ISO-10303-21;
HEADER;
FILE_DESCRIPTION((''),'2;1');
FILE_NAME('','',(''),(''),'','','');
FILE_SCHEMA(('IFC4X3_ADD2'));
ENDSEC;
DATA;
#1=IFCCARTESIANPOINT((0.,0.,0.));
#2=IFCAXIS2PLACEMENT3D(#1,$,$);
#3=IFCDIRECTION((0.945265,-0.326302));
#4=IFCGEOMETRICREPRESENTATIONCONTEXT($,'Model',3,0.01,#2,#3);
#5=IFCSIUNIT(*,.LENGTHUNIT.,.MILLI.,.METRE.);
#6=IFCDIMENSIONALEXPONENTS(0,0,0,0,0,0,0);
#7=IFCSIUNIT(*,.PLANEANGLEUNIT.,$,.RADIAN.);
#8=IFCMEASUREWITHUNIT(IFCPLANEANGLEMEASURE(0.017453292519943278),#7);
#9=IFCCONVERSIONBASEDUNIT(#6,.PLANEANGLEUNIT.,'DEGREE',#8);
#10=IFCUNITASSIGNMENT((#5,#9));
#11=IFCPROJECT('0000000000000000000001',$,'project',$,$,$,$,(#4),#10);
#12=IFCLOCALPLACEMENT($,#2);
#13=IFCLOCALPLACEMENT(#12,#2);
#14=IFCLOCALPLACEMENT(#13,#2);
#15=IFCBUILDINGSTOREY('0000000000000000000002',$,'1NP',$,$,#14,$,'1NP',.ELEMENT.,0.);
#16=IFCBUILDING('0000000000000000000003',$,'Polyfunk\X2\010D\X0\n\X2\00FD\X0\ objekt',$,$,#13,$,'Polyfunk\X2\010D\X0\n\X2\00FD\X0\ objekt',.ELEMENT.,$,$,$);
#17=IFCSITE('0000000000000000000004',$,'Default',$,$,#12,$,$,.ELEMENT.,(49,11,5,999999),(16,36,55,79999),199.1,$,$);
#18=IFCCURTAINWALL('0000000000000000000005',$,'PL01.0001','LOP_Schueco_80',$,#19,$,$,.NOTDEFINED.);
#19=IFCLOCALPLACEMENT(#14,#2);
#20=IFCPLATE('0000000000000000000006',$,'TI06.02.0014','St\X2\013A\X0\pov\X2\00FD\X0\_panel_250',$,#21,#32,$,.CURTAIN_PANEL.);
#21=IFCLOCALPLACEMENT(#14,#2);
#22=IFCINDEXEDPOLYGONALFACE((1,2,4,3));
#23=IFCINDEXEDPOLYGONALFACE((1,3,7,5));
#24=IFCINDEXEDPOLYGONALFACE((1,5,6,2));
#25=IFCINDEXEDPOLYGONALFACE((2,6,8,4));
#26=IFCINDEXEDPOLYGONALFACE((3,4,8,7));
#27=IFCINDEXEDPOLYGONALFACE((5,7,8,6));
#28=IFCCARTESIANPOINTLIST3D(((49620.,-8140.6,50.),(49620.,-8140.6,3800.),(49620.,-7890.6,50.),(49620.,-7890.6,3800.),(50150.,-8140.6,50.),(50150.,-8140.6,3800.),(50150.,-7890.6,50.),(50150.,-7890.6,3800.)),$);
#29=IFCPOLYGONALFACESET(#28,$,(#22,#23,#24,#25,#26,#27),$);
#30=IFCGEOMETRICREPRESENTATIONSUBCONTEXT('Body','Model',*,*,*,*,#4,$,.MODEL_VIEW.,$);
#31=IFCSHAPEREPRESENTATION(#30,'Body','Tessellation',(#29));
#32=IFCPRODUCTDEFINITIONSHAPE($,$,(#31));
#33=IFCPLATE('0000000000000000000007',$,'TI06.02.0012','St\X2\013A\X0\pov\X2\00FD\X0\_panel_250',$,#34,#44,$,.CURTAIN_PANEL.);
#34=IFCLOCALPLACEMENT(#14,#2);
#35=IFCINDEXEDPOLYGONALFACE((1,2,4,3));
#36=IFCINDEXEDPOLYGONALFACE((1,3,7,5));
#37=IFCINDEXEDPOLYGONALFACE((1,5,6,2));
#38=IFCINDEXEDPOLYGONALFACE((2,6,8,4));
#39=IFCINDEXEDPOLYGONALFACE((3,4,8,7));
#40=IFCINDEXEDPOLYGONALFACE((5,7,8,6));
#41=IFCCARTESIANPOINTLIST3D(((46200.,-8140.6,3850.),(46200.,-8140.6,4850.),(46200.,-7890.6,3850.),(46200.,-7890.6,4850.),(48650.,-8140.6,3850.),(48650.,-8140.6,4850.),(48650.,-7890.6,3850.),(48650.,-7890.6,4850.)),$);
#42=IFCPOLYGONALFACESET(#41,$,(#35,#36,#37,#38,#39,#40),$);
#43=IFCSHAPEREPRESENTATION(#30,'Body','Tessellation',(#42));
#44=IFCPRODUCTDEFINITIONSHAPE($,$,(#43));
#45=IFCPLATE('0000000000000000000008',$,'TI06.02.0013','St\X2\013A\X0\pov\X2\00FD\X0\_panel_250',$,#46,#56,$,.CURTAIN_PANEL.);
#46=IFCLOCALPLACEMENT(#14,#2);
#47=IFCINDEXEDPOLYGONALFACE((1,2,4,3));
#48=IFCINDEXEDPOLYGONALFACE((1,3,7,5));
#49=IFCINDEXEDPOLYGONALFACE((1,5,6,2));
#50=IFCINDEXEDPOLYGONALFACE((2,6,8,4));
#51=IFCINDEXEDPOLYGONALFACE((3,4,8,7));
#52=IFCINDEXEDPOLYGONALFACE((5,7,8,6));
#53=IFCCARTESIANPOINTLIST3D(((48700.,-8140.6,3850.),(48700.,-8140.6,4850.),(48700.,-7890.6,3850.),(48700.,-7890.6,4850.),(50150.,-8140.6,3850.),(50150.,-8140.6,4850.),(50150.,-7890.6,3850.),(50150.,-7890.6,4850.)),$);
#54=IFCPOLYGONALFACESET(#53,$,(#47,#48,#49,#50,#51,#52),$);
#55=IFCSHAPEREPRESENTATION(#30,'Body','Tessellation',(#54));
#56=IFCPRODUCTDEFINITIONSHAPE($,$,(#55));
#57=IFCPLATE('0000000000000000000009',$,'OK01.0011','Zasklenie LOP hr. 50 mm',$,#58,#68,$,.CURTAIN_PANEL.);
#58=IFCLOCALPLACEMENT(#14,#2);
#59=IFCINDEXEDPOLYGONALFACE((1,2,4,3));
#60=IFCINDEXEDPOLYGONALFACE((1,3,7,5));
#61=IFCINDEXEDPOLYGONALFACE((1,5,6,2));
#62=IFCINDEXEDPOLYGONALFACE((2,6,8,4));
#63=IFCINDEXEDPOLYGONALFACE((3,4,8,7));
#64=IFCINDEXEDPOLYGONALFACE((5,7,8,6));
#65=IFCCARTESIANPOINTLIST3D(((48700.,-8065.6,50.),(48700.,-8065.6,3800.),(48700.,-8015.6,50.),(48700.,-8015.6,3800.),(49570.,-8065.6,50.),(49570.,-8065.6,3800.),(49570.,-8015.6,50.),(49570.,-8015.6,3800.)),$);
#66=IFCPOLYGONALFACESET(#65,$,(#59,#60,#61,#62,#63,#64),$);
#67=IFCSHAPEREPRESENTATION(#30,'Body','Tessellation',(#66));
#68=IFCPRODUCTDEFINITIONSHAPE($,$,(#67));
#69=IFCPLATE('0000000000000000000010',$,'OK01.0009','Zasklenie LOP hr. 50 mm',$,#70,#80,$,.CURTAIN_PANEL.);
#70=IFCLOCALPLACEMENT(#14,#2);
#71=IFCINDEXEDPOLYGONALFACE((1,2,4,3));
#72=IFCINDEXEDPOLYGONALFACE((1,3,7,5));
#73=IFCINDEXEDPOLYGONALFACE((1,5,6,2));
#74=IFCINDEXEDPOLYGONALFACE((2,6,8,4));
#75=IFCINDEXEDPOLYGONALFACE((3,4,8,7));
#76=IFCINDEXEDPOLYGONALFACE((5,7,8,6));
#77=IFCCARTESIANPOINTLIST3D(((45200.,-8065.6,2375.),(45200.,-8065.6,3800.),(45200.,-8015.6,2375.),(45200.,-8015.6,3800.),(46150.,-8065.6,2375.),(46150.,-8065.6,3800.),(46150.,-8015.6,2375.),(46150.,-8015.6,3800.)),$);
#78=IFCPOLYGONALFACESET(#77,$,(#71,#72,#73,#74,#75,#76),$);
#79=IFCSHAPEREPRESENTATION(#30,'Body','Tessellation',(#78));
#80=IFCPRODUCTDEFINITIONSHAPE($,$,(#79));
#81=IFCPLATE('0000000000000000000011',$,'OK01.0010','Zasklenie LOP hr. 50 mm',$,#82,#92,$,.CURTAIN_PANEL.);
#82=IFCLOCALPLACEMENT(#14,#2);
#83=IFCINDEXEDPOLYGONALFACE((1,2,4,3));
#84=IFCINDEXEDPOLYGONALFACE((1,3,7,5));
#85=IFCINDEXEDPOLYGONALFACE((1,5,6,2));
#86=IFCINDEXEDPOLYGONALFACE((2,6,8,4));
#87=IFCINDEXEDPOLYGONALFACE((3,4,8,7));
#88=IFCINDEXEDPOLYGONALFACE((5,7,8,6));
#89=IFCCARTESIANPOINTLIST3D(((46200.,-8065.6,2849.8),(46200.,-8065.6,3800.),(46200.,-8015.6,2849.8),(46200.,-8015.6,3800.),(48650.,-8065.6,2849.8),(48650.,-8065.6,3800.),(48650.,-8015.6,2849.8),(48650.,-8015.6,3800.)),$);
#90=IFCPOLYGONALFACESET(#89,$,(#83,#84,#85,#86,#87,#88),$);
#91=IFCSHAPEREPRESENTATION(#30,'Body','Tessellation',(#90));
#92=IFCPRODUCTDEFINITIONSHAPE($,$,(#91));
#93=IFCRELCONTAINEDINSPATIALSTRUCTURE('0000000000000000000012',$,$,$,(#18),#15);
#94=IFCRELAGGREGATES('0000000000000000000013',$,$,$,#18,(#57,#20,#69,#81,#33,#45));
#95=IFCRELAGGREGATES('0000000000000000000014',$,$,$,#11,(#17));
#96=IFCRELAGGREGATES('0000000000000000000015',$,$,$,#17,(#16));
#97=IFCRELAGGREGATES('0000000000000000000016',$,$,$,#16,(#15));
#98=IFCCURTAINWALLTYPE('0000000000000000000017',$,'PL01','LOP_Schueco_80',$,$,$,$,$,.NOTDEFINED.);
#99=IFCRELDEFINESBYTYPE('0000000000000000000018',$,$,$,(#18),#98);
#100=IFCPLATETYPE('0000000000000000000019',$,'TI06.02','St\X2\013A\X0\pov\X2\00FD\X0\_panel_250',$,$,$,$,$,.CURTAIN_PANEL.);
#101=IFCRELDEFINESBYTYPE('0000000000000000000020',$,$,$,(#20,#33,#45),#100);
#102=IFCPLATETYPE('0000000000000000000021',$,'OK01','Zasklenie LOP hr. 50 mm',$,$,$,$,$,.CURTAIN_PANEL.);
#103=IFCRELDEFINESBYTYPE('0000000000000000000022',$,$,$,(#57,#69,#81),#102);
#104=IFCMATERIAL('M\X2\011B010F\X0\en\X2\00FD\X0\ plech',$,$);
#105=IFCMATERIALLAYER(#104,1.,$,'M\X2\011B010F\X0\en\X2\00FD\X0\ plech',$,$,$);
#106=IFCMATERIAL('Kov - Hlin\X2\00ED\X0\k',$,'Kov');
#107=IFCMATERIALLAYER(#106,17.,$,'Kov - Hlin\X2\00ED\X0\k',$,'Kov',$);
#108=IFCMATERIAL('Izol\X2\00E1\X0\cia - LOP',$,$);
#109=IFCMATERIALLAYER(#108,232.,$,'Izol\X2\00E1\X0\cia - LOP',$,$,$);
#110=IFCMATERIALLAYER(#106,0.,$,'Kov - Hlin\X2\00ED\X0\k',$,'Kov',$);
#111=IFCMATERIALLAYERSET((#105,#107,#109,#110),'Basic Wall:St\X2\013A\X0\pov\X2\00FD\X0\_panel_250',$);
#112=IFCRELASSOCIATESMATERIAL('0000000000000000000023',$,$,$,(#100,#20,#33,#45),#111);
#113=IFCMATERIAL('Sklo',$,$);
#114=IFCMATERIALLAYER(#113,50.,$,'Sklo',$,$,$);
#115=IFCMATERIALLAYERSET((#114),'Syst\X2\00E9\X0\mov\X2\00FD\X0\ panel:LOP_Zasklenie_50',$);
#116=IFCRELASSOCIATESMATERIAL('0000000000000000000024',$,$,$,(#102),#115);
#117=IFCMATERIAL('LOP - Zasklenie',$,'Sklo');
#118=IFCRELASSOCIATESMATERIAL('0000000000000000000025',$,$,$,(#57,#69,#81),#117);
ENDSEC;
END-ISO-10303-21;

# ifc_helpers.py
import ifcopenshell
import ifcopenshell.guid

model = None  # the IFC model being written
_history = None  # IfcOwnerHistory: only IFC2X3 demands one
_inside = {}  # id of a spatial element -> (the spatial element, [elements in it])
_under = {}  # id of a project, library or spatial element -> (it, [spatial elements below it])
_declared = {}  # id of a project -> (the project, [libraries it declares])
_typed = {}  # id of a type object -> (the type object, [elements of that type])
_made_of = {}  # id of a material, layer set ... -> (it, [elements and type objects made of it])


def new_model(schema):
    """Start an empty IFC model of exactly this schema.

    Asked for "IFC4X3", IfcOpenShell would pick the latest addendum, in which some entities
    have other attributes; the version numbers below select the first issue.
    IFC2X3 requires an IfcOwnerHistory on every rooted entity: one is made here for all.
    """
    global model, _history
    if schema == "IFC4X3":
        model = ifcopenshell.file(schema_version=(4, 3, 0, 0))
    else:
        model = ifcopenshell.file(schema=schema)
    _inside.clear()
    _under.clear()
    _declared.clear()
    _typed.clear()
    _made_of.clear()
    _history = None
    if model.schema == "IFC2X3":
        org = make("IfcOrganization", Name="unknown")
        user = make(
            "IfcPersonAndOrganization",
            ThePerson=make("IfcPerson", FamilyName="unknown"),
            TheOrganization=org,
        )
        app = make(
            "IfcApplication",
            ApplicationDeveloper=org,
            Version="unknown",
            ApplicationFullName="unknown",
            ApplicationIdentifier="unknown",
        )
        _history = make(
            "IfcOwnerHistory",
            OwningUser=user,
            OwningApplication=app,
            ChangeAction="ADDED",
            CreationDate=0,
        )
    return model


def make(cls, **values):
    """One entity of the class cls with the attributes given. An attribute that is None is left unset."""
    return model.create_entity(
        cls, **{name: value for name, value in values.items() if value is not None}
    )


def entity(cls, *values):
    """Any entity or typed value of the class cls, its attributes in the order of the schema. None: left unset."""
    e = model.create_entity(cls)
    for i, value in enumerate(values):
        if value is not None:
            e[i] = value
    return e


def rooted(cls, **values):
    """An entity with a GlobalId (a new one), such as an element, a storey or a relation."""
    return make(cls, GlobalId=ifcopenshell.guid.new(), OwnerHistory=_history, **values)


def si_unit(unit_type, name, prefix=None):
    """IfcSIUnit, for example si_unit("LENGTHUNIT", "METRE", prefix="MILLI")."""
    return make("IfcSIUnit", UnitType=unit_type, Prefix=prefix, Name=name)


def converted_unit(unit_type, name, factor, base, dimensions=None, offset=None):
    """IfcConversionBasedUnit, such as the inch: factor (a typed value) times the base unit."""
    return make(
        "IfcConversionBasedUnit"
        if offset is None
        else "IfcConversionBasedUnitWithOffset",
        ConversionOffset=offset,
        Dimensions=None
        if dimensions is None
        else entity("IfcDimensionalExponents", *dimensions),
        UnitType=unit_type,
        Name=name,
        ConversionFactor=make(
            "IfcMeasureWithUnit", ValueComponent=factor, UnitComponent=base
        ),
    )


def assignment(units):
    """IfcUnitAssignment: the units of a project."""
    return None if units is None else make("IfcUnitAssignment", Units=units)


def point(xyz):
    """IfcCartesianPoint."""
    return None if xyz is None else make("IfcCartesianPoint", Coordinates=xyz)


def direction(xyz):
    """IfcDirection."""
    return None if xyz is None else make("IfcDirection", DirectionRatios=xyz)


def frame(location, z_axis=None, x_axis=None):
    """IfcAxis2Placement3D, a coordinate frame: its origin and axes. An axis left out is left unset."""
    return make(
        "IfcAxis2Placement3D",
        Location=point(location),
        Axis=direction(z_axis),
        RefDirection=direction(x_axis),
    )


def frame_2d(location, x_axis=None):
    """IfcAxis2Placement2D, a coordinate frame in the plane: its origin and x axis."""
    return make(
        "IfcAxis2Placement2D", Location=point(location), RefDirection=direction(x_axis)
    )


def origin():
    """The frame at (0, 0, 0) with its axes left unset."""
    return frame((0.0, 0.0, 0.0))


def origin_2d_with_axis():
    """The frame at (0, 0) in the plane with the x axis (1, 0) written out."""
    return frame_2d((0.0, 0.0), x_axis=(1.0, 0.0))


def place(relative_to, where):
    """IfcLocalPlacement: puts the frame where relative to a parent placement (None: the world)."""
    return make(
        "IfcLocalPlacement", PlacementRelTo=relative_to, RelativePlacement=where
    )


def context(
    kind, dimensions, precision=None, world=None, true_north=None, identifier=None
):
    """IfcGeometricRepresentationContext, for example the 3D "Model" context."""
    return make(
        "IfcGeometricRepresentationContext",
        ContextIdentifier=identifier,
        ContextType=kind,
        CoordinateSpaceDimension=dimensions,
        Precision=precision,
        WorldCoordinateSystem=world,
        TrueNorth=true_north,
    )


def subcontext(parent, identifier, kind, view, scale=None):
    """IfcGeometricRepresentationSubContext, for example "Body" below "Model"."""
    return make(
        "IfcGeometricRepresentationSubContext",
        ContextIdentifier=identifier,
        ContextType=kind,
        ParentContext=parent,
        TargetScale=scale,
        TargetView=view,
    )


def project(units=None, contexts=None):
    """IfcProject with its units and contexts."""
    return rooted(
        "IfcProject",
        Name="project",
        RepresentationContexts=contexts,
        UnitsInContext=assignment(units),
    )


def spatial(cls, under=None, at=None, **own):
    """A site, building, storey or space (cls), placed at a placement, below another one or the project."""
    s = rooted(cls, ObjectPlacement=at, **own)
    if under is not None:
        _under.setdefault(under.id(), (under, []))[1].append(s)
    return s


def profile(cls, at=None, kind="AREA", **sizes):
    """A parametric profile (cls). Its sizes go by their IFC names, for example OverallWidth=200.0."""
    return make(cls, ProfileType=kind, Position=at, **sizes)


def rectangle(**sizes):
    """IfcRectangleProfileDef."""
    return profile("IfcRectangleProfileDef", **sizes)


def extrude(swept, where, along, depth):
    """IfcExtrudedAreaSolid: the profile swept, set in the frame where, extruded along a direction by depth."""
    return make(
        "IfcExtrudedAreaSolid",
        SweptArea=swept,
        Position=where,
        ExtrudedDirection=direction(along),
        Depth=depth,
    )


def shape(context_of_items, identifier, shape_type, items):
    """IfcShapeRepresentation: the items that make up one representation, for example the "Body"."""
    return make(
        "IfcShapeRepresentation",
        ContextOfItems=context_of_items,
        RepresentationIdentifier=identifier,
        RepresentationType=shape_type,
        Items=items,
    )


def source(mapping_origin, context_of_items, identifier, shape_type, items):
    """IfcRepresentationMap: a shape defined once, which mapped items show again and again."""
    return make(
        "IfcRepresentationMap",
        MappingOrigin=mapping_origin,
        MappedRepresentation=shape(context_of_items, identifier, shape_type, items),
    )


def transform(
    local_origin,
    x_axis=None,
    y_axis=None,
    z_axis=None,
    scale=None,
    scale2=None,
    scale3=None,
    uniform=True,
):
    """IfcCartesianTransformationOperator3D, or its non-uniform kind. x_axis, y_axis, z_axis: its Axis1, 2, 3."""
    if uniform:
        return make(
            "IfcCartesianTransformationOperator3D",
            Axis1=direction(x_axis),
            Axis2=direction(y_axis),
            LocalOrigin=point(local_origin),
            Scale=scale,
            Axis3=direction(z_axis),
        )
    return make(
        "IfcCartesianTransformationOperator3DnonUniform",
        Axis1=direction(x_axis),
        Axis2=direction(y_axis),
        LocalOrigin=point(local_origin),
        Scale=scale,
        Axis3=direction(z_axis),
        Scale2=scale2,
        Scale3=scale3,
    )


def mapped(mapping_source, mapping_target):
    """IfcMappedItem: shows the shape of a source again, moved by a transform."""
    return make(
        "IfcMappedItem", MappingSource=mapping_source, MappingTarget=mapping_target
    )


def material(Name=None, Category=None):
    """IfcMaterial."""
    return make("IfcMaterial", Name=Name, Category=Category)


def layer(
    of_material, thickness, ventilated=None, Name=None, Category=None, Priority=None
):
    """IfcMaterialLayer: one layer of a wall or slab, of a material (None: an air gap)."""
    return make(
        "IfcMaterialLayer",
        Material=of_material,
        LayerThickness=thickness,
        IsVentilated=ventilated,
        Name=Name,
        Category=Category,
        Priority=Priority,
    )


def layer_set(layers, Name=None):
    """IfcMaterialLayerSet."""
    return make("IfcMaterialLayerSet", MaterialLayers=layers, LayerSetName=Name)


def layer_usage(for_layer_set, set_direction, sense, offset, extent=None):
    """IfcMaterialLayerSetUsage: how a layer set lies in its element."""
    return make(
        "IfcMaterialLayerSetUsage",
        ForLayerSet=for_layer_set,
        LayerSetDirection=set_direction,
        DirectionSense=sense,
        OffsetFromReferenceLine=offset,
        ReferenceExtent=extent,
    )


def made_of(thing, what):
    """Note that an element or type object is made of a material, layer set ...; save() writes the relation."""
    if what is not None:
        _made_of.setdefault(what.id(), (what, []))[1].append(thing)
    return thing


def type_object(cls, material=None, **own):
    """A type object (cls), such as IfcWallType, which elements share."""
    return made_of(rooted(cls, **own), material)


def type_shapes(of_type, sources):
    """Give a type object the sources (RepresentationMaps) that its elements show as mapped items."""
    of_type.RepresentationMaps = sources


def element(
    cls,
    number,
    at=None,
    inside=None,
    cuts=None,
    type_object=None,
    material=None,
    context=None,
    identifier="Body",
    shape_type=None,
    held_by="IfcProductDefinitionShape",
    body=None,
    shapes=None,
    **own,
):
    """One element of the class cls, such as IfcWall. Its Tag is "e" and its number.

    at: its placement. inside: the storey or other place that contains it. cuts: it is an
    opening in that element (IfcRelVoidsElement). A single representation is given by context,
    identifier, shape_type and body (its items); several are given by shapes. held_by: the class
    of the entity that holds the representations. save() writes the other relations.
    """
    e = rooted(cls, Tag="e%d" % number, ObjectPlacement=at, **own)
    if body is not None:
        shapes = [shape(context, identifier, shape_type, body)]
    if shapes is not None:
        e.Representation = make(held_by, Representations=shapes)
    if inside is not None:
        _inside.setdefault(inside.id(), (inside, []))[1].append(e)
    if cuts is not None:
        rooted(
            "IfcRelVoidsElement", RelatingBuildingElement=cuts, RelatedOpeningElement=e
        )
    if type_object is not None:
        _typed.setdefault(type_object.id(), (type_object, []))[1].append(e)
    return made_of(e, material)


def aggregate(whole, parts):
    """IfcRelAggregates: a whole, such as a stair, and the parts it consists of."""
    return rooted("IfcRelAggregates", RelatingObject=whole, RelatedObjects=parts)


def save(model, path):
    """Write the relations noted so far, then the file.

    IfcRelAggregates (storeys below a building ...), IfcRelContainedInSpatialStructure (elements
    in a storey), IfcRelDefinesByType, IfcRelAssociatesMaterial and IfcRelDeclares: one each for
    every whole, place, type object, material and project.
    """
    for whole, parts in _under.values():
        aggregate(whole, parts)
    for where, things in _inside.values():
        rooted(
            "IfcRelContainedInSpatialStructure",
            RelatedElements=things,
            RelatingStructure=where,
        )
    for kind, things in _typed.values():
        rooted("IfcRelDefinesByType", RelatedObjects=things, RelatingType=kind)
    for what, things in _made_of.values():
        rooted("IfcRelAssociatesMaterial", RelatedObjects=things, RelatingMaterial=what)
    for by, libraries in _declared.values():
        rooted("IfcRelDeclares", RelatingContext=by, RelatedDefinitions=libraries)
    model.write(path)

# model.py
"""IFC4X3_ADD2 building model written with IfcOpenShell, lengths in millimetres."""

from ifc_helpers import new_model, entity, si_unit, converted_unit, direction, frame, frame_2d, origin, origin_2d_with_axis, place, context, subcontext, project, spatial, rectangle, extrude, source, transform, mapped, material, layer, layer_set, layer_usage, type_object, type_shapes, element, aggregate, save


model = new_model("IFC4X3_ADD2")

# Units and contexts
model_context = context("Model", 3, precision=0.01, world=origin(), true_north=direction((0.945265, -0.326302)))
body_context = subcontext(model_context, "Body", "Model", "MODEL_VIEW")
ifc_project = project(units=[si_unit("LENGTHUNIT", "METRE", prefix="MILLI"), converted_unit("PLANEANGLEUNIT", "DEGREE", entity("IfcPlaneAngleMeasure", 0.017453292519943278), si_unit("PLANEANGLEUNIT", "RADIAN"), dimensions=[0, 0, 0, 0, 0, 0, 0])], contexts=[model_context])

# Site, building, storey
site_placement = place(None, origin())
site = spatial("IfcSite", under=ifc_project, at=site_placement, Name="Default", CompositionType="ELEMENT", RefLatitude=(49, 11, 5, 999999), RefLongitude=(16, 36, 55, 79999), RefElevation=199.1)
building_placement = place(site_placement, origin())
building = spatial("IfcBuilding", under=site, at=building_placement, Name="Polyfunkčný objekt", LongName="Polyfunkčný objekt", CompositionType="ELEMENT")
storey_placement = place(building_placement, origin())
storey = spatial("IfcBuildingStorey", under=building, at=storey_placement, Name="1NP", LongName="1NP", CompositionType="ELEMENT", Elevation=0.0)

# Curtain wall, plates
curtain_wall_type = type_object("IfcCurtainWallType", Name="PL01", Description="LOP_Schueco_80", PredefinedType="NOTDEFINED")
curtain_wall_placement = place(storey_placement, origin())
curtain_wall = element("IfcCurtainWall", 1, at=curtain_wall_placement, inside=storey, type_object=curtain_wall_type, Name="PL01.0001", Description="LOP_Schueco_80", PredefinedType="NOTDEFINED")
ifc_material_1 = material(Name="Měďený plech")
ifc_layer_1 = layer(ifc_material_1, 1.0, Name="Měďený plech")
ifc_material_2 = material(Name="Kov - Hliník", Category="Kov")
ifc_layer_2 = layer(ifc_material_2, 17.0, Name="Kov - Hliník", Category="Kov")
ifc_material_3 = material(Name="Izolácia - LOP")
ifc_layer_3 = layer(ifc_material_3, 232.0, Name="Izolácia - LOP")
ifc_layer_4 = layer(ifc_material_2, 0.0, Name="Kov - Hliník", Category="Kov")
ifc_layer_set_1 = layer_set([ifc_layer_1, ifc_layer_2, ifc_layer_3, ifc_layer_4], Name="Basic Wall:Stĺpový_panel_250")
ifc_layer_usage_1 = layer_usage(ifc_layer_set_1, "AXIS2", "POSITIVE", -125.0)
plate_type_1 = type_object("IfcPlateType", Name="TI06.02", Description="Stĺpový_panel_250", PredefinedType="CURTAIN_PANEL", material=ifc_layer_set_1)
plate_1_placement = place(storey_placement, frame((49620.0, -8015.6, 50.0)))
plate_1 = element("IfcPlate", 2, at=plate_1_placement, type_object=plate_type_1, material=ifc_layer_usage_1, Name="TI06.02.0014", Description="Stĺpový_panel_250", PredefinedType="CURTAIN_PANEL", context=body_context, shape_type="SweptSolid", body=[
    extrude(rectangle(XDim=250.0, YDim=530.0, at=frame_2d((0.0, 0.0), x_axis=(1.0, 0.0))), frame((265.0, 0.0, 0.0), z_axis=(0.0, 0.0, 1.0), x_axis=(0.0, 1.0, 0.0)), (0.0, 0.0, 1.0), 3750.0),
])
ifc_layer_usage_2 = layer_usage(ifc_layer_set_1, "AXIS2", "POSITIVE", -125.0)
plate_2_placement = place(storey_placement, frame((46200.0, -8015.6, 3850.0)))
plate_2 = element("IfcPlate", 3, at=plate_2_placement, type_object=plate_type_1, material=ifc_layer_usage_2, Name="TI06.02.0012", Description="Stĺpový_panel_250", PredefinedType="CURTAIN_PANEL", context=body_context, shape_type="SweptSolid", body=[
    extrude(rectangle(XDim=250.0, YDim=2450.0, at=origin_2d_with_axis()), frame((1225.0, 0.0, 0.0), z_axis=(0.0, 0.0, 1.0), x_axis=(0.0, 1.0, 0.0)), (0.0, 0.0, 1.0), 1000.0),
])
ifc_layer_usage_3 = layer_usage(ifc_layer_set_1, "AXIS2", "POSITIVE", -125.0)
plate_3_placement = place(storey_placement, frame((48700.0, -8015.6, 3850.0)))
plate_3 = element("IfcPlate", 4, at=plate_3_placement, type_object=plate_type_1, material=ifc_layer_usage_3, Name="TI06.02.0013", Description="Stĺpový_panel_250", PredefinedType="CURTAIN_PANEL", context=body_context, shape_type="SweptSolid", body=[
    extrude(rectangle(XDim=250.0, YDim=1450.0, at=frame_2d((0.0, 0.0), x_axis=(1.0, 0.0))), frame((725.0, 0.0, 0.0), z_axis=(0.0, 0.0, 1.0), x_axis=(0.0, 1.0, 0.0)), (0.0, 0.0, 1.0), 1000.0),
])
ifc_material_4 = material(Name="LOP - Zasklenie", Category="Sklo")
ifc_material_5 = material(Name="Sklo")
ifc_layer_5 = layer(ifc_material_5, 50.0, Name="Sklo")
ifc_layer_set_2 = layer_set([ifc_layer_5], Name="Systémový panel:LOP_Zasklenie_50")
plate_type_2 = type_object("IfcPlateType", Name="OK01", Description="Zasklenie LOP hr. 50 mm", PredefinedType="CURTAIN_PANEL", material=ifc_layer_set_2)
shared_shape_1 = source(origin(), body_context, "Body", "SweptSolid", [
    extrude(rectangle(XDim=3750.0, YDim=870.0, at=frame_2d((-331.2, 0.0), x_axis=(1.0, 0.0))), frame((0.0, -50.0, 2206.2), z_axis=(0.0, 1.0, 0.0), x_axis=(0.0, 0.0, 1.0)), (0.0, 0.0, 1.0), 50.0),
])
plate_4_placement = place(curtain_wall_placement, frame((49135.0, -8015.6, 50.0)))
plate_4 = element("IfcPlate", 5, at=plate_4_placement, type_object=plate_type_2, material=ifc_material_4, Name="OK01.0011", Description="Zasklenie LOP hr. 50 mm", PredefinedType="CURTAIN_PANEL", context=body_context, shape_type="MappedRepresentation", body=[
    mapped(shared_shape_1, transform((0.0, 0.0, 0.0), scale=1.0)),
])
shared_shape_2 = source(origin(), body_context, "Body", "SweptSolid", [
    extrude(rectangle(XDim=1425.0, YDim=950.0, at=frame_2d((87.6, 0.0), x_axis=(1.0, 0.0))), frame((0.0, -50.0, 624.9), z_axis=(0.0, 1.0, 0.0), x_axis=(0.0, 0.0, 1.0)), (0.0, 0.0, 1.0), 50.0),
])
plate_5_placement = place(curtain_wall_placement, frame((45675.0, -8015.6, 2375.0)))
plate_5 = element("IfcPlate", 6, at=plate_5_placement, type_object=plate_type_2, material=ifc_material_4, Name="OK01.0009", Description="Zasklenie LOP hr. 50 mm", PredefinedType="CURTAIN_PANEL", context=body_context, shape_type="MappedRepresentation", body=[
    mapped(shared_shape_2, transform((0.0, 0.0, 0.0), scale=1.0)),
])
shared_shape_3 = source(origin(), body_context, "Body", "SweptSolid", [
    extrude(rectangle(XDim=50.0, YDim=2450.0, at=origin_2d_with_axis()), frame((0.0, -25.0, 0.0), z_axis=(0.0, 0.0, 1.0), x_axis=(0.0, 1.0, 0.0)), (0.0, 0.0, 1.0), 950.2),
])
type_shapes(plate_type_2, [shared_shape_1, shared_shape_2, shared_shape_3])
plate_6_placement = place(curtain_wall_placement, frame((47425.0, -8015.6, 2849.8)))
plate_6 = element("IfcPlate", 7, at=plate_6_placement, type_object=plate_type_2, material=ifc_material_4, Name="OK01.0010", Description="Zasklenie LOP hr. 50 mm", PredefinedType="CURTAIN_PANEL", context=body_context, shape_type="MappedRepresentation", body=[
    mapped(shared_shape_3, transform((0.0, 0.0, 0.0), scale=1.0)),
])
aggregate(curtain_wall, [plate_4, plate_1, plate_5, plate_6, plate_2, plate_3])

save(model, "model.ifc")
